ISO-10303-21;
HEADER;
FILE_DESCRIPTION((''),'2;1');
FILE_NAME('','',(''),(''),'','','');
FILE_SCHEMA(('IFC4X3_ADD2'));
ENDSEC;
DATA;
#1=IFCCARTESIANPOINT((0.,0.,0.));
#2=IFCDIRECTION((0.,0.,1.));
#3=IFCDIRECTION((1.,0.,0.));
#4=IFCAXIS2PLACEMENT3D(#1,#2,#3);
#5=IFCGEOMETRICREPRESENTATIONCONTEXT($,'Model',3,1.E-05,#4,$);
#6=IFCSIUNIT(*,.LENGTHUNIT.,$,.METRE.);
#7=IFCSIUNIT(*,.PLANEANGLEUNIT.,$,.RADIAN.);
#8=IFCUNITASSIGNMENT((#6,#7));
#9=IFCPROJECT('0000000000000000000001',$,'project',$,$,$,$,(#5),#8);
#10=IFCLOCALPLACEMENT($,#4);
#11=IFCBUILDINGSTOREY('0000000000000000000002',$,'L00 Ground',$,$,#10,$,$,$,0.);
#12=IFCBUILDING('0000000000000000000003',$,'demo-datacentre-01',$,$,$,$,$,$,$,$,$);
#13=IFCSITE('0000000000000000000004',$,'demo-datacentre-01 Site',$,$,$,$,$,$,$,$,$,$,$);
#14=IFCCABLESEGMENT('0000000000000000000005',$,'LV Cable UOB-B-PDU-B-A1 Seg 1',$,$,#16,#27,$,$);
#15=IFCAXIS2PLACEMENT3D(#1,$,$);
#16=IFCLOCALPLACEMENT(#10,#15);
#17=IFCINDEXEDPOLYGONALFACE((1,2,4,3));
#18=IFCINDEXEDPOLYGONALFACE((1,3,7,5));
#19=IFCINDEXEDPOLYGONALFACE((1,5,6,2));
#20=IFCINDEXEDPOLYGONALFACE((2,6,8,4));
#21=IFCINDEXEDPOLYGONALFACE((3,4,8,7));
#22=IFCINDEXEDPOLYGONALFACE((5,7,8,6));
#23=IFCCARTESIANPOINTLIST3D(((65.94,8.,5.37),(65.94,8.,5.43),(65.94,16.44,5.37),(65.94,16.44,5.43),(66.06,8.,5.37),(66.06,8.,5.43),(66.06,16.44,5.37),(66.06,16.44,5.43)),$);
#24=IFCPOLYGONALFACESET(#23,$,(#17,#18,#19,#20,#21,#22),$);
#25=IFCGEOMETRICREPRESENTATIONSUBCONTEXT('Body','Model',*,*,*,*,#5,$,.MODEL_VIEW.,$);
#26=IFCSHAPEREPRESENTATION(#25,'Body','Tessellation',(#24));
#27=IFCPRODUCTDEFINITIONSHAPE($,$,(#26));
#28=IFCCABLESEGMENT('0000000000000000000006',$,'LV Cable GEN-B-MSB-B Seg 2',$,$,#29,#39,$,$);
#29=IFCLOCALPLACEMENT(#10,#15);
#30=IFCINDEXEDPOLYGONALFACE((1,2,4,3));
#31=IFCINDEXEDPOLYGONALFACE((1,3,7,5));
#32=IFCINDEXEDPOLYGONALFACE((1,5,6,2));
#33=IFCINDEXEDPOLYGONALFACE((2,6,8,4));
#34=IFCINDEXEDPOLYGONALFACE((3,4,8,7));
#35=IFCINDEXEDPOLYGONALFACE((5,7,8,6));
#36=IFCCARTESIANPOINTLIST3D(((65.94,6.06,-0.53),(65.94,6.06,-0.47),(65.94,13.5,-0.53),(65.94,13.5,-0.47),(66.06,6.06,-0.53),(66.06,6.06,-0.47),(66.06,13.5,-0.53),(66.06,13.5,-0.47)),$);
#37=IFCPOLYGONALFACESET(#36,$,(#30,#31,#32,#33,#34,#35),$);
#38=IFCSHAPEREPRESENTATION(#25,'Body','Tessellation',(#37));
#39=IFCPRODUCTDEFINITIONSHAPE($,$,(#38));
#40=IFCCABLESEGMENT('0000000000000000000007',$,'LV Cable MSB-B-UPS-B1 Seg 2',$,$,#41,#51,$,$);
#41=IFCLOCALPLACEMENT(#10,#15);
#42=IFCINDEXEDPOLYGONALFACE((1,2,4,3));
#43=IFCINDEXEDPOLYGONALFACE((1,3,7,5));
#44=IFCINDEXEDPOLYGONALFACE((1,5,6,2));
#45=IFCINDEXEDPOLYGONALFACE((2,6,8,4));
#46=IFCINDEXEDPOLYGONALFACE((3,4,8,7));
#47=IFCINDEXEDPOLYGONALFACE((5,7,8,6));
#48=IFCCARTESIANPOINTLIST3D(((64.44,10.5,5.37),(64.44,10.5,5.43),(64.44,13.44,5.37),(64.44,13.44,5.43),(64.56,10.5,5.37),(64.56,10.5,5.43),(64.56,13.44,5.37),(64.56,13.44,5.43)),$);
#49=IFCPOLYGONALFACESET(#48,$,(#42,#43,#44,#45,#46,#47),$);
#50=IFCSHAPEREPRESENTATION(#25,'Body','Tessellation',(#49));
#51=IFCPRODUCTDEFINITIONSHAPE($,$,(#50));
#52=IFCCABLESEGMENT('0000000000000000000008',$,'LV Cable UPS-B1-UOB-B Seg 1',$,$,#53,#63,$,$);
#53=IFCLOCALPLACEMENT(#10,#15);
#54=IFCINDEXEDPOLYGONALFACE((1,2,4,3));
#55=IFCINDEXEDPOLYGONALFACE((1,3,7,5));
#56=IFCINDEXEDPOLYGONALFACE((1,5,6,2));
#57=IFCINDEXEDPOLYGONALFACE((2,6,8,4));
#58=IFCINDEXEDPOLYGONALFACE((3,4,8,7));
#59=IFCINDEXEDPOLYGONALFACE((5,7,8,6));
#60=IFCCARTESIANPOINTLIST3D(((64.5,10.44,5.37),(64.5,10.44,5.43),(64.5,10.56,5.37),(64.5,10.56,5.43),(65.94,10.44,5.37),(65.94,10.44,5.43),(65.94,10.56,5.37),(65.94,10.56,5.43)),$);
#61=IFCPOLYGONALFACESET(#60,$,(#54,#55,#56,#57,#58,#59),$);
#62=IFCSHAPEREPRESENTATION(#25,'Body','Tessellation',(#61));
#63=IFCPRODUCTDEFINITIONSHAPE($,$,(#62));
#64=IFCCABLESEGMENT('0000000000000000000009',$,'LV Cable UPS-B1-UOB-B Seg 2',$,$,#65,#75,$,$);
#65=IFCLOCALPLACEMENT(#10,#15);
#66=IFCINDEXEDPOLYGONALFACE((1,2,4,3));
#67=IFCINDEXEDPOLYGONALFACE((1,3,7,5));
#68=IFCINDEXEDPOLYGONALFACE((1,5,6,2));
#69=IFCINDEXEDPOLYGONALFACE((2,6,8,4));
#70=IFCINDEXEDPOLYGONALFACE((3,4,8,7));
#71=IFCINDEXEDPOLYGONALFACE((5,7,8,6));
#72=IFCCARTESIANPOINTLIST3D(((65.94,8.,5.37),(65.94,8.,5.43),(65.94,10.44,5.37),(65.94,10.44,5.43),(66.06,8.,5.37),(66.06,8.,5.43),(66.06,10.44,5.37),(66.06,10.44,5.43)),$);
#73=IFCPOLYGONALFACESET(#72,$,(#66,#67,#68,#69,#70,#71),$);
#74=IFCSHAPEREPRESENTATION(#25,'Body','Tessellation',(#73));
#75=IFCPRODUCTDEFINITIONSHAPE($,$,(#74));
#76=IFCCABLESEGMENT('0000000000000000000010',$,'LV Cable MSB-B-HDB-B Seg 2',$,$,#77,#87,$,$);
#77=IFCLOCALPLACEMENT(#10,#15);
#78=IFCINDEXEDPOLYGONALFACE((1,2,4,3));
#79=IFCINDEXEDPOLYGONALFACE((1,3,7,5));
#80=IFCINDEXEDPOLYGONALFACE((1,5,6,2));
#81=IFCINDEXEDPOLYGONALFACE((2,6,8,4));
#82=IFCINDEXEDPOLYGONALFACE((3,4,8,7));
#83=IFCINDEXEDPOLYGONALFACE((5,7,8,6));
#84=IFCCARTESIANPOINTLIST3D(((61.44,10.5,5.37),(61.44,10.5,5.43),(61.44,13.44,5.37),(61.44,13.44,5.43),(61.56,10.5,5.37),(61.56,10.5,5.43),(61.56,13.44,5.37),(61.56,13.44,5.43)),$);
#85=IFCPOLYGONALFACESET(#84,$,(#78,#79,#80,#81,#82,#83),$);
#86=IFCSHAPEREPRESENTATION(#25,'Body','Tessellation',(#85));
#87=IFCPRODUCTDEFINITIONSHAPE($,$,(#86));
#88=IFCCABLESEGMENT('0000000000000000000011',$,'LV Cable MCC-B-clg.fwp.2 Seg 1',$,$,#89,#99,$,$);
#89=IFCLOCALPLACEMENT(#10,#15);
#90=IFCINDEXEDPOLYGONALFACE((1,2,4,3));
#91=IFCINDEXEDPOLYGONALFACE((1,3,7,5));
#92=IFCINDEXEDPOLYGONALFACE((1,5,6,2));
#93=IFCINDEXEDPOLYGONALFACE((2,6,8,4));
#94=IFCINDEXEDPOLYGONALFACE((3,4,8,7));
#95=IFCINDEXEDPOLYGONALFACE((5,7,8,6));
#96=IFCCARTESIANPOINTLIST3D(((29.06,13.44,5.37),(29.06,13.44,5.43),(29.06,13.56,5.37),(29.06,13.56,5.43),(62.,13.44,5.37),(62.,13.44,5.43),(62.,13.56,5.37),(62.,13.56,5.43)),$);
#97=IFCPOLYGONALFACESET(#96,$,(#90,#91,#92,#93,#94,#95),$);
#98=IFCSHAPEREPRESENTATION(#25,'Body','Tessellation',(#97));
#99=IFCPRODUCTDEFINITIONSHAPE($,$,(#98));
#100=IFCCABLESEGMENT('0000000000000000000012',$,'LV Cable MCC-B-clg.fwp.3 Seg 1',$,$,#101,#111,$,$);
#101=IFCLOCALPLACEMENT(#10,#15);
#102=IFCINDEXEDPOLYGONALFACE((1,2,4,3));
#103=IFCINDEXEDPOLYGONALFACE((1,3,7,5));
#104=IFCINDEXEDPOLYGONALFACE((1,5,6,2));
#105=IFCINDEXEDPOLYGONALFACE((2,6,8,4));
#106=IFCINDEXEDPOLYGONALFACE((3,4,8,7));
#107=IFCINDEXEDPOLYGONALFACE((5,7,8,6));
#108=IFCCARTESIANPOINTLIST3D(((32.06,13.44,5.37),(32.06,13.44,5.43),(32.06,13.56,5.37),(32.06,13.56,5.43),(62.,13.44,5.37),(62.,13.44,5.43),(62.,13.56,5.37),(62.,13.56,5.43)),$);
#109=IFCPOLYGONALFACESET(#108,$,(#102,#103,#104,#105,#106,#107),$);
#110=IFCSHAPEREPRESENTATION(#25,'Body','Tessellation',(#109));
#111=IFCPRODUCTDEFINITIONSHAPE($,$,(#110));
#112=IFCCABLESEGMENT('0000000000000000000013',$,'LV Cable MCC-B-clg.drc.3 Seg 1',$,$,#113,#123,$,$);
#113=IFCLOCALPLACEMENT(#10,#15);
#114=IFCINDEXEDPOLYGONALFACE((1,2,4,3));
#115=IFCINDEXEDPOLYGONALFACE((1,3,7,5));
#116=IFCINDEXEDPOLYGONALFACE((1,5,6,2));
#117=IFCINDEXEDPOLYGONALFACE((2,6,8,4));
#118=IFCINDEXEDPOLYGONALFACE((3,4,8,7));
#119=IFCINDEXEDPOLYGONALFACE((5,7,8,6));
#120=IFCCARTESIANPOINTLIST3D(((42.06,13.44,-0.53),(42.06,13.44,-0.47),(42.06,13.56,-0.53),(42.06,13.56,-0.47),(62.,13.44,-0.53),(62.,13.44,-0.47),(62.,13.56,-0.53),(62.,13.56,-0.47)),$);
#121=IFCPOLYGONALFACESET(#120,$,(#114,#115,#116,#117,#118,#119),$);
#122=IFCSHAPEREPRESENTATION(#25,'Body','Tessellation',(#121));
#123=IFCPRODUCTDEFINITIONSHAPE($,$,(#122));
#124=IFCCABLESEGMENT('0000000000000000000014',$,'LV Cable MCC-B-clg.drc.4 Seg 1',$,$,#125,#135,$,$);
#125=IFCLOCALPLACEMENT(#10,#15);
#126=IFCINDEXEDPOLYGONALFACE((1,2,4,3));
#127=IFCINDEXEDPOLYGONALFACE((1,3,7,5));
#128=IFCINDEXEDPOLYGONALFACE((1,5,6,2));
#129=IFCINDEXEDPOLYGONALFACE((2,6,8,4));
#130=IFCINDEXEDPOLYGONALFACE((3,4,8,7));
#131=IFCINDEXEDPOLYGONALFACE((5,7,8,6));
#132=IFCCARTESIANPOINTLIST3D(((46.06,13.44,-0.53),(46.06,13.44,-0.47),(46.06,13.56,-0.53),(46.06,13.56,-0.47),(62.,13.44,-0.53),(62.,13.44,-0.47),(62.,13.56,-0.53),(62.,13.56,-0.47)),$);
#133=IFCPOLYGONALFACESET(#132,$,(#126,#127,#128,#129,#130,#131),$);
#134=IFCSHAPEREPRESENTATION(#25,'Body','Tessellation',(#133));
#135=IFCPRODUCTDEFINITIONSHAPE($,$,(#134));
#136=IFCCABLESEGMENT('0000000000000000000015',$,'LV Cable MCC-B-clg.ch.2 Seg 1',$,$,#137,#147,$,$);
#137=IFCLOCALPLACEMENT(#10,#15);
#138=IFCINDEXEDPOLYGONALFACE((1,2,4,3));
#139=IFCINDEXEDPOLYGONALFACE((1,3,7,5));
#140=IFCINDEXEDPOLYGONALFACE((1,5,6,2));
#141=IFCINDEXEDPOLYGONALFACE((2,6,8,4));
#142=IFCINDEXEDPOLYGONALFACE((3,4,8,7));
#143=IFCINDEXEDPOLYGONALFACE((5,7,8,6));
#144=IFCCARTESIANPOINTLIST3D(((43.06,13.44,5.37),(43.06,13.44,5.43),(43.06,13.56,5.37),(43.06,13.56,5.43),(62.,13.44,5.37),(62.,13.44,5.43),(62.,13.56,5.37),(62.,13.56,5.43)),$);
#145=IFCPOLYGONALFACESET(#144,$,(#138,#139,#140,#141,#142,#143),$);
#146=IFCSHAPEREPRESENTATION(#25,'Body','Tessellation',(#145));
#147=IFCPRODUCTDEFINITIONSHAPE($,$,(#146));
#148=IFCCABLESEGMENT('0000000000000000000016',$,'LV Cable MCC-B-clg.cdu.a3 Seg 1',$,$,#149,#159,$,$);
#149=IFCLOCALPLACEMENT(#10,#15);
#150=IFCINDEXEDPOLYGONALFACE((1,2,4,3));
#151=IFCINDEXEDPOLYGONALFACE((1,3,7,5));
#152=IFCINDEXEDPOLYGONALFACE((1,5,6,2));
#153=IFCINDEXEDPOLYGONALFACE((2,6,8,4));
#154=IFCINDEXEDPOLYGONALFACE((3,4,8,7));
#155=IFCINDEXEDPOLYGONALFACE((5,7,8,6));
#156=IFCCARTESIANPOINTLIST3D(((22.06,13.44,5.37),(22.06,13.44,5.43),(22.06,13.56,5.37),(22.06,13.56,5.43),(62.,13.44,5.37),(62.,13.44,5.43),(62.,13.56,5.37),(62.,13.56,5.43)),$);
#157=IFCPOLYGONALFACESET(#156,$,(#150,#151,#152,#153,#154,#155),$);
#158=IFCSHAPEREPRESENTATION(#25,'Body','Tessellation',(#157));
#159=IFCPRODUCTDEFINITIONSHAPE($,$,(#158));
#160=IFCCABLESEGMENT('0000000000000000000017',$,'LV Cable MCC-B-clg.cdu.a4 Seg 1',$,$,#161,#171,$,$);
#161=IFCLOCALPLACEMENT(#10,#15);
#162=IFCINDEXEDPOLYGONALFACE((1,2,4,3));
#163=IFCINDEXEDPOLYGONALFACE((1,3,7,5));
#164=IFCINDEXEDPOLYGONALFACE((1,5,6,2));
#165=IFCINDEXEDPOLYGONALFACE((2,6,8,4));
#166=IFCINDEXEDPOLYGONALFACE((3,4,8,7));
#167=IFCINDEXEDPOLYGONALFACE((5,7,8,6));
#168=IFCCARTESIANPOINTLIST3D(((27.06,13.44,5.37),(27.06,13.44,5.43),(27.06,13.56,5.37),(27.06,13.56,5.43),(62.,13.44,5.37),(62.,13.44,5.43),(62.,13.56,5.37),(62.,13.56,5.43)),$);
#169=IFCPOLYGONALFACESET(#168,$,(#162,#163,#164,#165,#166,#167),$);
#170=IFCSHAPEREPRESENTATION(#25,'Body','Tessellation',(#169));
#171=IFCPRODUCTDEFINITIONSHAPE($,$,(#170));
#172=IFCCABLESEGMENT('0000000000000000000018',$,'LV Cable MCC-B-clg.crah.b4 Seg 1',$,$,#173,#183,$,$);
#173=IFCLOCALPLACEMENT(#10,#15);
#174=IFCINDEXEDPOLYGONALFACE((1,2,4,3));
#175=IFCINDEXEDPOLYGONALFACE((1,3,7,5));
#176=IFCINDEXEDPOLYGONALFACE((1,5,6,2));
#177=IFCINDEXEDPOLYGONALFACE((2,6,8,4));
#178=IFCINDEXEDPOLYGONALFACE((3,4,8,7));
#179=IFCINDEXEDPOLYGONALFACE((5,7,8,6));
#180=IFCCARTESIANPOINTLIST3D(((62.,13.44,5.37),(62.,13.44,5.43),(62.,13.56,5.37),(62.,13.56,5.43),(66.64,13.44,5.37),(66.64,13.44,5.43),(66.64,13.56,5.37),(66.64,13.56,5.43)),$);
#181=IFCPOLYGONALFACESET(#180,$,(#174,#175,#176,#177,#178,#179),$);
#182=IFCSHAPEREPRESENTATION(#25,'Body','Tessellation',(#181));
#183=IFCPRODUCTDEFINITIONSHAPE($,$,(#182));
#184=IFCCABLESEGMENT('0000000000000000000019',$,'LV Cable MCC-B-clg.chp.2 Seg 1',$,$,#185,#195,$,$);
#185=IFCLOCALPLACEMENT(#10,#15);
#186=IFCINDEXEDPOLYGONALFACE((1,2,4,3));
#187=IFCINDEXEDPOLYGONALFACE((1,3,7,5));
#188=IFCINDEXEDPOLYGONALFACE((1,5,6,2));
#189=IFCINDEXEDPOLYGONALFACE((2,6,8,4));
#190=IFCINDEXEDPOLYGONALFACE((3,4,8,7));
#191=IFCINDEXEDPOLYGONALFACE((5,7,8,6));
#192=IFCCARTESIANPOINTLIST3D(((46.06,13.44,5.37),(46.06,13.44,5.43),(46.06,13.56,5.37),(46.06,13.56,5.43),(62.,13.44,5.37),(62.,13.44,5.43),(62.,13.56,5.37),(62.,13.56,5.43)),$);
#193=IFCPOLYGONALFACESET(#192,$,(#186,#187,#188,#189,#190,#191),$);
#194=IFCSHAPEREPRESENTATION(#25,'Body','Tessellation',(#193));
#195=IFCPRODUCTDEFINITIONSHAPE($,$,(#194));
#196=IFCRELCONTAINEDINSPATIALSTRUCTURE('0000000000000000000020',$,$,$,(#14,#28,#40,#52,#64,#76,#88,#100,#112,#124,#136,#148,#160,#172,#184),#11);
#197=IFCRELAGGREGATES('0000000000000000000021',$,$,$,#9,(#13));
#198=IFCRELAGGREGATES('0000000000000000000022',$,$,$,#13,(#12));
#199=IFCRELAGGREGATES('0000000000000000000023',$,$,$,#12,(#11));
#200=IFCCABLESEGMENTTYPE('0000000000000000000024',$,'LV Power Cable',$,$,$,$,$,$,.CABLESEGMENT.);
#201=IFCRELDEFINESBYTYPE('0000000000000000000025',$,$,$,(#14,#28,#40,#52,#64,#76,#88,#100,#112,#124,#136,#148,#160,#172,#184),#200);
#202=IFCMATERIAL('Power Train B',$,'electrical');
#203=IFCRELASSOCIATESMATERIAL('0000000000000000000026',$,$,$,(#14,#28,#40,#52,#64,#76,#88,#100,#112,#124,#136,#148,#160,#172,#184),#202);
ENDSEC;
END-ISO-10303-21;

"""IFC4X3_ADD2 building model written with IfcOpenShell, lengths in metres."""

from ifc_helpers import new_model, si_unit, frame, origin_with_axes, place, context, subcontext, project, spatial, rectangle, extrude, material, type_object, element, save


model = new_model("IFC4X3_ADD2")

# Units and contexts
model_context = context("Model", 3, precision=1e-05, world=origin_with_axes())
body_context = subcontext(model_context, "Body", "Model", "MODEL_VIEW")
ifc_project = project(units=[si_unit("LENGTHUNIT", "METRE"), si_unit("PLANEANGLEUNIT", "RADIAN")], contexts=[model_context])

# Site, building, storey
site = spatial("IfcSite", under=ifc_project, Name="demo-datacentre-01 Site")
building = spatial("IfcBuilding", under=site, Name="demo-datacentre-01")
storey_placement = place(None, origin_with_axes())
storey = spatial("IfcBuildingStorey", under=building, at=storey_placement, Name="L00 Ground", Elevation=0.0)

# Shared definitions
ifc_material = material(Name="Power Train B", Category="electrical")

# Cable segments
cable_segment_type_1 = type_object("IfcCableSegmentType", Name="LV Power Cable", PredefinedType="CABLESEGMENT")
for number, where, z_axis, x_axis, name in (
    (1, (66.0, 8.0, 5.4), (0.0, 1.0, 0.0), (-1.0, 0.0, 0.0), "LV Cable UOB-B-PDU-B-A1 Seg 1"),
):
    element("IfcCableSegment", number, at=place(storey_placement, frame(where, z_axis=z_axis, x_axis=x_axis)), inside=storey, type_object=cable_segment_type_1, material=ifc_material, Name=name, context=body_context, shape_type="SweptSolid", body=[
        extrude(rectangle(XDim=0.12, YDim=0.06), origin_with_axes(), (0.0, 0.0, 1.0), 8.44),
    ])
cable_segment_1_placement = place(storey_placement, frame((66.0, 6.06, -0.5), z_axis=(0.0, 1.0, 0.0), x_axis=(-1.0, 0.0, 0.0)))
element("IfcCableSegment", 2, at=cable_segment_1_placement, inside=storey, type_object=cable_segment_type_1, material=ifc_material, Name="LV Cable GEN-B-MSB-B Seg 2", context=body_context, shape_type="SweptSolid", body=[
    extrude(rectangle(XDim=0.12, YDim=0.06), origin_with_axes(), (0.0, 0.0, 1.0), 7.44),
])
cable_segment_2_placement = place(storey_placement, frame((64.5, 13.44, 5.4), z_axis=(0.0, -1.0, 0.0), x_axis=(1.0, 0.0, 0.0)))
element("IfcCableSegment", 3, at=cable_segment_2_placement, inside=storey, type_object=cable_segment_type_1, material=ifc_material, Name="LV Cable MSB-B-UPS-B1 Seg 2", context=body_context, shape_type="SweptSolid", body=[
    extrude(rectangle(XDim=0.12, YDim=0.06), origin_with_axes(), (0.0, 0.0, 1.0), 2.94),
])
cable_segment_3_placement = place(storey_placement, frame((64.5, 10.5, 5.4), z_axis=(1.0, 0.0, 0.0), x_axis=(0.0, 1.0, 0.0)))
element("IfcCableSegment", 4, at=cable_segment_3_placement, inside=storey, type_object=cable_segment_type_1, material=ifc_material, Name="LV Cable UPS-B1-UOB-B Seg 1", context=body_context, shape_type="SweptSolid", body=[
    extrude(rectangle(XDim=0.12, YDim=0.06), origin_with_axes(), (0.0, 0.0, 1.0), 1.44),
])
for number, where, z_axis, x_axis, name in (
    (5, (66.0, 10.44, 5.4), (0.0, -1.0, 0.0), (1.0, 0.0, 0.0), "LV Cable UPS-B1-UOB-B Seg 2"),
):
    element("IfcCableSegment", number, at=place(storey_placement, frame(where, z_axis=z_axis, x_axis=x_axis)), inside=storey, type_object=cable_segment_type_1, material=ifc_material, Name=name, context=body_context, shape_type="SweptSolid", body=[
        extrude(rectangle(XDim=0.12, YDim=0.06), origin_with_axes(), (0.0, 0.0, 1.0), 2.44),
    ])
cable_segment_4_placement = place(storey_placement, frame((61.5, 13.44, 5.4), z_axis=(0.0, -1.0, 0.0), x_axis=(1.0, 0.0, 0.0)))
element("IfcCableSegment", 6, at=cable_segment_4_placement, inside=storey, type_object=cable_segment_type_1, material=ifc_material, Name="LV Cable MSB-B-HDB-B Seg 2", context=body_context, shape_type="SweptSolid", body=[
    extrude(rectangle(XDim=0.12, YDim=0.06), origin_with_axes(), (0.0, 0.0, 1.0), 2.94),
])
cable_segment_5_placement = place(storey_placement, frame((62.0, 13.5, 5.4), z_axis=(-1.0, 0.0, 0.0), x_axis=(0.0, -1.0, 0.0)))
element("IfcCableSegment", 7, at=cable_segment_5_placement, inside=storey, type_object=cable_segment_type_1, material=ifc_material, Name="LV Cable MCC-B-clg.fwp.2 Seg 1", context=body_context, shape_type="SweptSolid", body=[
    extrude(rectangle(XDim=0.12, YDim=0.06), origin_with_axes(), (0.0, 0.0, 1.0), 32.94),
])
cable_segment_6_placement = place(storey_placement, frame((62.0, 13.5, 5.4), z_axis=(-1.0, 0.0, 0.0), x_axis=(0.0, -1.0, 0.0)))
element("IfcCableSegment", 8, at=cable_segment_6_placement, inside=storey, type_object=cable_segment_type_1, material=ifc_material, Name="LV Cable MCC-B-clg.fwp.3 Seg 1", context=body_context, shape_type="SweptSolid", body=[
    extrude(rectangle(XDim=0.12, YDim=0.06), origin_with_axes(), (0.0, 0.0, 1.0), 29.94),
])
cable_segment_7_placement = place(storey_placement, frame((62.0, 13.5, -0.5), z_axis=(-1.0, 0.0, 0.0), x_axis=(0.0, -1.0, 0.0)))
element("IfcCableSegment", 9, at=cable_segment_7_placement, inside=storey, type_object=cable_segment_type_1, material=ifc_material, Name="LV Cable MCC-B-clg.drc.3 Seg 1", context=body_context, shape_type="SweptSolid", body=[
    extrude(rectangle(XDim=0.12, YDim=0.06), origin_with_axes(), (0.0, 0.0, 1.0), 19.94),
])
cable_segment_8_placement = place(storey_placement, frame((62.0, 13.5, -0.5), z_axis=(-1.0, 0.0, 0.0), x_axis=(0.0, -1.0, 0.0)))
element("IfcCableSegment", 10, at=cable_segment_8_placement, inside=storey, type_object=cable_segment_type_1, material=ifc_material, Name="LV Cable MCC-B-clg.drc.4 Seg 1", context=body_context, shape_type="SweptSolid", body=[
    extrude(rectangle(XDim=0.12, YDim=0.06), origin_with_axes(), (0.0, 0.0, 1.0), 15.94),
])
cable_segment_9_placement = place(storey_placement, frame((62.0, 13.5, 5.4), z_axis=(-1.0, 0.0, 0.0), x_axis=(0.0, -1.0, 0.0)))
element("IfcCableSegment", 11, at=cable_segment_9_placement, inside=storey, type_object=cable_segment_type_1, material=ifc_material, Name="LV Cable MCC-B-clg.ch.2 Seg 1", context=body_context, shape_type="SweptSolid", body=[
    extrude(rectangle(XDim=0.12, YDim=0.06), origin_with_axes(), (0.0, 0.0, 1.0), 18.94),
])
cable_segment_10_placement = place(storey_placement, frame((62.0, 13.5, 5.4), z_axis=(-1.0, 0.0, 0.0), x_axis=(0.0, -1.0, 0.0)))
element("IfcCableSegment", 12, at=cable_segment_10_placement, inside=storey, type_object=cable_segment_type_1, material=ifc_material, Name="LV Cable MCC-B-clg.cdu.a3 Seg 1", context=body_context, shape_type="SweptSolid", body=[
    extrude(rectangle(XDim=0.12, YDim=0.06), origin_with_axes(), (0.0, 0.0, 1.0), 39.94),
])
cable_segment_11_placement = place(storey_placement, frame((62.0, 13.5, 5.4), z_axis=(-1.0, 0.0, 0.0), x_axis=(0.0, -1.0, 0.0)))
element("IfcCableSegment", 13, at=cable_segment_11_placement, inside=storey, type_object=cable_segment_type_1, material=ifc_material, Name="LV Cable MCC-B-clg.cdu.a4 Seg 1", context=body_context, shape_type="SweptSolid", body=[
    extrude(rectangle(XDim=0.12, YDim=0.06), origin_with_axes(), (0.0, 0.0, 1.0), 34.94),
])
for number, where, z_axis, x_axis, name in (
    (14, (62.0, 13.5, 5.4), (1.0, 0.0, 0.0), (0.0, 1.0, 0.0), "LV Cable MCC-B-clg.crah.b4 Seg 1"),
):
    element("IfcCableSegment", number, at=place(storey_placement, frame(where, z_axis=z_axis, x_axis=x_axis)), inside=storey, type_object=cable_segment_type_1, material=ifc_material, Name=name, context=body_context, shape_type="SweptSolid", body=[
        extrude(rectangle(XDim=0.12, YDim=0.06), origin_with_axes(), (0.0, 0.0, 1.0), 4.64),
    ])
cable_segment_12_placement = place(storey_placement, frame((62.0, 13.5, 5.4), z_axis=(-1.0, 0.0, 0.0), x_axis=(0.0, -1.0, 0.0)))
element("IfcCableSegment", 15, at=cable_segment_12_placement, inside=storey, type_object=cable_segment_type_1, material=ifc_material, Name="LV Cable MCC-B-clg.chp.2 Seg 1", context=body_context, shape_type="SweptSolid", body=[
    extrude(rectangle(XDim=0.12, YDim=0.06), origin_with_axes(), (0.0, 0.0, 1.0), 15.94),
])

save(model, "model.ifc")
